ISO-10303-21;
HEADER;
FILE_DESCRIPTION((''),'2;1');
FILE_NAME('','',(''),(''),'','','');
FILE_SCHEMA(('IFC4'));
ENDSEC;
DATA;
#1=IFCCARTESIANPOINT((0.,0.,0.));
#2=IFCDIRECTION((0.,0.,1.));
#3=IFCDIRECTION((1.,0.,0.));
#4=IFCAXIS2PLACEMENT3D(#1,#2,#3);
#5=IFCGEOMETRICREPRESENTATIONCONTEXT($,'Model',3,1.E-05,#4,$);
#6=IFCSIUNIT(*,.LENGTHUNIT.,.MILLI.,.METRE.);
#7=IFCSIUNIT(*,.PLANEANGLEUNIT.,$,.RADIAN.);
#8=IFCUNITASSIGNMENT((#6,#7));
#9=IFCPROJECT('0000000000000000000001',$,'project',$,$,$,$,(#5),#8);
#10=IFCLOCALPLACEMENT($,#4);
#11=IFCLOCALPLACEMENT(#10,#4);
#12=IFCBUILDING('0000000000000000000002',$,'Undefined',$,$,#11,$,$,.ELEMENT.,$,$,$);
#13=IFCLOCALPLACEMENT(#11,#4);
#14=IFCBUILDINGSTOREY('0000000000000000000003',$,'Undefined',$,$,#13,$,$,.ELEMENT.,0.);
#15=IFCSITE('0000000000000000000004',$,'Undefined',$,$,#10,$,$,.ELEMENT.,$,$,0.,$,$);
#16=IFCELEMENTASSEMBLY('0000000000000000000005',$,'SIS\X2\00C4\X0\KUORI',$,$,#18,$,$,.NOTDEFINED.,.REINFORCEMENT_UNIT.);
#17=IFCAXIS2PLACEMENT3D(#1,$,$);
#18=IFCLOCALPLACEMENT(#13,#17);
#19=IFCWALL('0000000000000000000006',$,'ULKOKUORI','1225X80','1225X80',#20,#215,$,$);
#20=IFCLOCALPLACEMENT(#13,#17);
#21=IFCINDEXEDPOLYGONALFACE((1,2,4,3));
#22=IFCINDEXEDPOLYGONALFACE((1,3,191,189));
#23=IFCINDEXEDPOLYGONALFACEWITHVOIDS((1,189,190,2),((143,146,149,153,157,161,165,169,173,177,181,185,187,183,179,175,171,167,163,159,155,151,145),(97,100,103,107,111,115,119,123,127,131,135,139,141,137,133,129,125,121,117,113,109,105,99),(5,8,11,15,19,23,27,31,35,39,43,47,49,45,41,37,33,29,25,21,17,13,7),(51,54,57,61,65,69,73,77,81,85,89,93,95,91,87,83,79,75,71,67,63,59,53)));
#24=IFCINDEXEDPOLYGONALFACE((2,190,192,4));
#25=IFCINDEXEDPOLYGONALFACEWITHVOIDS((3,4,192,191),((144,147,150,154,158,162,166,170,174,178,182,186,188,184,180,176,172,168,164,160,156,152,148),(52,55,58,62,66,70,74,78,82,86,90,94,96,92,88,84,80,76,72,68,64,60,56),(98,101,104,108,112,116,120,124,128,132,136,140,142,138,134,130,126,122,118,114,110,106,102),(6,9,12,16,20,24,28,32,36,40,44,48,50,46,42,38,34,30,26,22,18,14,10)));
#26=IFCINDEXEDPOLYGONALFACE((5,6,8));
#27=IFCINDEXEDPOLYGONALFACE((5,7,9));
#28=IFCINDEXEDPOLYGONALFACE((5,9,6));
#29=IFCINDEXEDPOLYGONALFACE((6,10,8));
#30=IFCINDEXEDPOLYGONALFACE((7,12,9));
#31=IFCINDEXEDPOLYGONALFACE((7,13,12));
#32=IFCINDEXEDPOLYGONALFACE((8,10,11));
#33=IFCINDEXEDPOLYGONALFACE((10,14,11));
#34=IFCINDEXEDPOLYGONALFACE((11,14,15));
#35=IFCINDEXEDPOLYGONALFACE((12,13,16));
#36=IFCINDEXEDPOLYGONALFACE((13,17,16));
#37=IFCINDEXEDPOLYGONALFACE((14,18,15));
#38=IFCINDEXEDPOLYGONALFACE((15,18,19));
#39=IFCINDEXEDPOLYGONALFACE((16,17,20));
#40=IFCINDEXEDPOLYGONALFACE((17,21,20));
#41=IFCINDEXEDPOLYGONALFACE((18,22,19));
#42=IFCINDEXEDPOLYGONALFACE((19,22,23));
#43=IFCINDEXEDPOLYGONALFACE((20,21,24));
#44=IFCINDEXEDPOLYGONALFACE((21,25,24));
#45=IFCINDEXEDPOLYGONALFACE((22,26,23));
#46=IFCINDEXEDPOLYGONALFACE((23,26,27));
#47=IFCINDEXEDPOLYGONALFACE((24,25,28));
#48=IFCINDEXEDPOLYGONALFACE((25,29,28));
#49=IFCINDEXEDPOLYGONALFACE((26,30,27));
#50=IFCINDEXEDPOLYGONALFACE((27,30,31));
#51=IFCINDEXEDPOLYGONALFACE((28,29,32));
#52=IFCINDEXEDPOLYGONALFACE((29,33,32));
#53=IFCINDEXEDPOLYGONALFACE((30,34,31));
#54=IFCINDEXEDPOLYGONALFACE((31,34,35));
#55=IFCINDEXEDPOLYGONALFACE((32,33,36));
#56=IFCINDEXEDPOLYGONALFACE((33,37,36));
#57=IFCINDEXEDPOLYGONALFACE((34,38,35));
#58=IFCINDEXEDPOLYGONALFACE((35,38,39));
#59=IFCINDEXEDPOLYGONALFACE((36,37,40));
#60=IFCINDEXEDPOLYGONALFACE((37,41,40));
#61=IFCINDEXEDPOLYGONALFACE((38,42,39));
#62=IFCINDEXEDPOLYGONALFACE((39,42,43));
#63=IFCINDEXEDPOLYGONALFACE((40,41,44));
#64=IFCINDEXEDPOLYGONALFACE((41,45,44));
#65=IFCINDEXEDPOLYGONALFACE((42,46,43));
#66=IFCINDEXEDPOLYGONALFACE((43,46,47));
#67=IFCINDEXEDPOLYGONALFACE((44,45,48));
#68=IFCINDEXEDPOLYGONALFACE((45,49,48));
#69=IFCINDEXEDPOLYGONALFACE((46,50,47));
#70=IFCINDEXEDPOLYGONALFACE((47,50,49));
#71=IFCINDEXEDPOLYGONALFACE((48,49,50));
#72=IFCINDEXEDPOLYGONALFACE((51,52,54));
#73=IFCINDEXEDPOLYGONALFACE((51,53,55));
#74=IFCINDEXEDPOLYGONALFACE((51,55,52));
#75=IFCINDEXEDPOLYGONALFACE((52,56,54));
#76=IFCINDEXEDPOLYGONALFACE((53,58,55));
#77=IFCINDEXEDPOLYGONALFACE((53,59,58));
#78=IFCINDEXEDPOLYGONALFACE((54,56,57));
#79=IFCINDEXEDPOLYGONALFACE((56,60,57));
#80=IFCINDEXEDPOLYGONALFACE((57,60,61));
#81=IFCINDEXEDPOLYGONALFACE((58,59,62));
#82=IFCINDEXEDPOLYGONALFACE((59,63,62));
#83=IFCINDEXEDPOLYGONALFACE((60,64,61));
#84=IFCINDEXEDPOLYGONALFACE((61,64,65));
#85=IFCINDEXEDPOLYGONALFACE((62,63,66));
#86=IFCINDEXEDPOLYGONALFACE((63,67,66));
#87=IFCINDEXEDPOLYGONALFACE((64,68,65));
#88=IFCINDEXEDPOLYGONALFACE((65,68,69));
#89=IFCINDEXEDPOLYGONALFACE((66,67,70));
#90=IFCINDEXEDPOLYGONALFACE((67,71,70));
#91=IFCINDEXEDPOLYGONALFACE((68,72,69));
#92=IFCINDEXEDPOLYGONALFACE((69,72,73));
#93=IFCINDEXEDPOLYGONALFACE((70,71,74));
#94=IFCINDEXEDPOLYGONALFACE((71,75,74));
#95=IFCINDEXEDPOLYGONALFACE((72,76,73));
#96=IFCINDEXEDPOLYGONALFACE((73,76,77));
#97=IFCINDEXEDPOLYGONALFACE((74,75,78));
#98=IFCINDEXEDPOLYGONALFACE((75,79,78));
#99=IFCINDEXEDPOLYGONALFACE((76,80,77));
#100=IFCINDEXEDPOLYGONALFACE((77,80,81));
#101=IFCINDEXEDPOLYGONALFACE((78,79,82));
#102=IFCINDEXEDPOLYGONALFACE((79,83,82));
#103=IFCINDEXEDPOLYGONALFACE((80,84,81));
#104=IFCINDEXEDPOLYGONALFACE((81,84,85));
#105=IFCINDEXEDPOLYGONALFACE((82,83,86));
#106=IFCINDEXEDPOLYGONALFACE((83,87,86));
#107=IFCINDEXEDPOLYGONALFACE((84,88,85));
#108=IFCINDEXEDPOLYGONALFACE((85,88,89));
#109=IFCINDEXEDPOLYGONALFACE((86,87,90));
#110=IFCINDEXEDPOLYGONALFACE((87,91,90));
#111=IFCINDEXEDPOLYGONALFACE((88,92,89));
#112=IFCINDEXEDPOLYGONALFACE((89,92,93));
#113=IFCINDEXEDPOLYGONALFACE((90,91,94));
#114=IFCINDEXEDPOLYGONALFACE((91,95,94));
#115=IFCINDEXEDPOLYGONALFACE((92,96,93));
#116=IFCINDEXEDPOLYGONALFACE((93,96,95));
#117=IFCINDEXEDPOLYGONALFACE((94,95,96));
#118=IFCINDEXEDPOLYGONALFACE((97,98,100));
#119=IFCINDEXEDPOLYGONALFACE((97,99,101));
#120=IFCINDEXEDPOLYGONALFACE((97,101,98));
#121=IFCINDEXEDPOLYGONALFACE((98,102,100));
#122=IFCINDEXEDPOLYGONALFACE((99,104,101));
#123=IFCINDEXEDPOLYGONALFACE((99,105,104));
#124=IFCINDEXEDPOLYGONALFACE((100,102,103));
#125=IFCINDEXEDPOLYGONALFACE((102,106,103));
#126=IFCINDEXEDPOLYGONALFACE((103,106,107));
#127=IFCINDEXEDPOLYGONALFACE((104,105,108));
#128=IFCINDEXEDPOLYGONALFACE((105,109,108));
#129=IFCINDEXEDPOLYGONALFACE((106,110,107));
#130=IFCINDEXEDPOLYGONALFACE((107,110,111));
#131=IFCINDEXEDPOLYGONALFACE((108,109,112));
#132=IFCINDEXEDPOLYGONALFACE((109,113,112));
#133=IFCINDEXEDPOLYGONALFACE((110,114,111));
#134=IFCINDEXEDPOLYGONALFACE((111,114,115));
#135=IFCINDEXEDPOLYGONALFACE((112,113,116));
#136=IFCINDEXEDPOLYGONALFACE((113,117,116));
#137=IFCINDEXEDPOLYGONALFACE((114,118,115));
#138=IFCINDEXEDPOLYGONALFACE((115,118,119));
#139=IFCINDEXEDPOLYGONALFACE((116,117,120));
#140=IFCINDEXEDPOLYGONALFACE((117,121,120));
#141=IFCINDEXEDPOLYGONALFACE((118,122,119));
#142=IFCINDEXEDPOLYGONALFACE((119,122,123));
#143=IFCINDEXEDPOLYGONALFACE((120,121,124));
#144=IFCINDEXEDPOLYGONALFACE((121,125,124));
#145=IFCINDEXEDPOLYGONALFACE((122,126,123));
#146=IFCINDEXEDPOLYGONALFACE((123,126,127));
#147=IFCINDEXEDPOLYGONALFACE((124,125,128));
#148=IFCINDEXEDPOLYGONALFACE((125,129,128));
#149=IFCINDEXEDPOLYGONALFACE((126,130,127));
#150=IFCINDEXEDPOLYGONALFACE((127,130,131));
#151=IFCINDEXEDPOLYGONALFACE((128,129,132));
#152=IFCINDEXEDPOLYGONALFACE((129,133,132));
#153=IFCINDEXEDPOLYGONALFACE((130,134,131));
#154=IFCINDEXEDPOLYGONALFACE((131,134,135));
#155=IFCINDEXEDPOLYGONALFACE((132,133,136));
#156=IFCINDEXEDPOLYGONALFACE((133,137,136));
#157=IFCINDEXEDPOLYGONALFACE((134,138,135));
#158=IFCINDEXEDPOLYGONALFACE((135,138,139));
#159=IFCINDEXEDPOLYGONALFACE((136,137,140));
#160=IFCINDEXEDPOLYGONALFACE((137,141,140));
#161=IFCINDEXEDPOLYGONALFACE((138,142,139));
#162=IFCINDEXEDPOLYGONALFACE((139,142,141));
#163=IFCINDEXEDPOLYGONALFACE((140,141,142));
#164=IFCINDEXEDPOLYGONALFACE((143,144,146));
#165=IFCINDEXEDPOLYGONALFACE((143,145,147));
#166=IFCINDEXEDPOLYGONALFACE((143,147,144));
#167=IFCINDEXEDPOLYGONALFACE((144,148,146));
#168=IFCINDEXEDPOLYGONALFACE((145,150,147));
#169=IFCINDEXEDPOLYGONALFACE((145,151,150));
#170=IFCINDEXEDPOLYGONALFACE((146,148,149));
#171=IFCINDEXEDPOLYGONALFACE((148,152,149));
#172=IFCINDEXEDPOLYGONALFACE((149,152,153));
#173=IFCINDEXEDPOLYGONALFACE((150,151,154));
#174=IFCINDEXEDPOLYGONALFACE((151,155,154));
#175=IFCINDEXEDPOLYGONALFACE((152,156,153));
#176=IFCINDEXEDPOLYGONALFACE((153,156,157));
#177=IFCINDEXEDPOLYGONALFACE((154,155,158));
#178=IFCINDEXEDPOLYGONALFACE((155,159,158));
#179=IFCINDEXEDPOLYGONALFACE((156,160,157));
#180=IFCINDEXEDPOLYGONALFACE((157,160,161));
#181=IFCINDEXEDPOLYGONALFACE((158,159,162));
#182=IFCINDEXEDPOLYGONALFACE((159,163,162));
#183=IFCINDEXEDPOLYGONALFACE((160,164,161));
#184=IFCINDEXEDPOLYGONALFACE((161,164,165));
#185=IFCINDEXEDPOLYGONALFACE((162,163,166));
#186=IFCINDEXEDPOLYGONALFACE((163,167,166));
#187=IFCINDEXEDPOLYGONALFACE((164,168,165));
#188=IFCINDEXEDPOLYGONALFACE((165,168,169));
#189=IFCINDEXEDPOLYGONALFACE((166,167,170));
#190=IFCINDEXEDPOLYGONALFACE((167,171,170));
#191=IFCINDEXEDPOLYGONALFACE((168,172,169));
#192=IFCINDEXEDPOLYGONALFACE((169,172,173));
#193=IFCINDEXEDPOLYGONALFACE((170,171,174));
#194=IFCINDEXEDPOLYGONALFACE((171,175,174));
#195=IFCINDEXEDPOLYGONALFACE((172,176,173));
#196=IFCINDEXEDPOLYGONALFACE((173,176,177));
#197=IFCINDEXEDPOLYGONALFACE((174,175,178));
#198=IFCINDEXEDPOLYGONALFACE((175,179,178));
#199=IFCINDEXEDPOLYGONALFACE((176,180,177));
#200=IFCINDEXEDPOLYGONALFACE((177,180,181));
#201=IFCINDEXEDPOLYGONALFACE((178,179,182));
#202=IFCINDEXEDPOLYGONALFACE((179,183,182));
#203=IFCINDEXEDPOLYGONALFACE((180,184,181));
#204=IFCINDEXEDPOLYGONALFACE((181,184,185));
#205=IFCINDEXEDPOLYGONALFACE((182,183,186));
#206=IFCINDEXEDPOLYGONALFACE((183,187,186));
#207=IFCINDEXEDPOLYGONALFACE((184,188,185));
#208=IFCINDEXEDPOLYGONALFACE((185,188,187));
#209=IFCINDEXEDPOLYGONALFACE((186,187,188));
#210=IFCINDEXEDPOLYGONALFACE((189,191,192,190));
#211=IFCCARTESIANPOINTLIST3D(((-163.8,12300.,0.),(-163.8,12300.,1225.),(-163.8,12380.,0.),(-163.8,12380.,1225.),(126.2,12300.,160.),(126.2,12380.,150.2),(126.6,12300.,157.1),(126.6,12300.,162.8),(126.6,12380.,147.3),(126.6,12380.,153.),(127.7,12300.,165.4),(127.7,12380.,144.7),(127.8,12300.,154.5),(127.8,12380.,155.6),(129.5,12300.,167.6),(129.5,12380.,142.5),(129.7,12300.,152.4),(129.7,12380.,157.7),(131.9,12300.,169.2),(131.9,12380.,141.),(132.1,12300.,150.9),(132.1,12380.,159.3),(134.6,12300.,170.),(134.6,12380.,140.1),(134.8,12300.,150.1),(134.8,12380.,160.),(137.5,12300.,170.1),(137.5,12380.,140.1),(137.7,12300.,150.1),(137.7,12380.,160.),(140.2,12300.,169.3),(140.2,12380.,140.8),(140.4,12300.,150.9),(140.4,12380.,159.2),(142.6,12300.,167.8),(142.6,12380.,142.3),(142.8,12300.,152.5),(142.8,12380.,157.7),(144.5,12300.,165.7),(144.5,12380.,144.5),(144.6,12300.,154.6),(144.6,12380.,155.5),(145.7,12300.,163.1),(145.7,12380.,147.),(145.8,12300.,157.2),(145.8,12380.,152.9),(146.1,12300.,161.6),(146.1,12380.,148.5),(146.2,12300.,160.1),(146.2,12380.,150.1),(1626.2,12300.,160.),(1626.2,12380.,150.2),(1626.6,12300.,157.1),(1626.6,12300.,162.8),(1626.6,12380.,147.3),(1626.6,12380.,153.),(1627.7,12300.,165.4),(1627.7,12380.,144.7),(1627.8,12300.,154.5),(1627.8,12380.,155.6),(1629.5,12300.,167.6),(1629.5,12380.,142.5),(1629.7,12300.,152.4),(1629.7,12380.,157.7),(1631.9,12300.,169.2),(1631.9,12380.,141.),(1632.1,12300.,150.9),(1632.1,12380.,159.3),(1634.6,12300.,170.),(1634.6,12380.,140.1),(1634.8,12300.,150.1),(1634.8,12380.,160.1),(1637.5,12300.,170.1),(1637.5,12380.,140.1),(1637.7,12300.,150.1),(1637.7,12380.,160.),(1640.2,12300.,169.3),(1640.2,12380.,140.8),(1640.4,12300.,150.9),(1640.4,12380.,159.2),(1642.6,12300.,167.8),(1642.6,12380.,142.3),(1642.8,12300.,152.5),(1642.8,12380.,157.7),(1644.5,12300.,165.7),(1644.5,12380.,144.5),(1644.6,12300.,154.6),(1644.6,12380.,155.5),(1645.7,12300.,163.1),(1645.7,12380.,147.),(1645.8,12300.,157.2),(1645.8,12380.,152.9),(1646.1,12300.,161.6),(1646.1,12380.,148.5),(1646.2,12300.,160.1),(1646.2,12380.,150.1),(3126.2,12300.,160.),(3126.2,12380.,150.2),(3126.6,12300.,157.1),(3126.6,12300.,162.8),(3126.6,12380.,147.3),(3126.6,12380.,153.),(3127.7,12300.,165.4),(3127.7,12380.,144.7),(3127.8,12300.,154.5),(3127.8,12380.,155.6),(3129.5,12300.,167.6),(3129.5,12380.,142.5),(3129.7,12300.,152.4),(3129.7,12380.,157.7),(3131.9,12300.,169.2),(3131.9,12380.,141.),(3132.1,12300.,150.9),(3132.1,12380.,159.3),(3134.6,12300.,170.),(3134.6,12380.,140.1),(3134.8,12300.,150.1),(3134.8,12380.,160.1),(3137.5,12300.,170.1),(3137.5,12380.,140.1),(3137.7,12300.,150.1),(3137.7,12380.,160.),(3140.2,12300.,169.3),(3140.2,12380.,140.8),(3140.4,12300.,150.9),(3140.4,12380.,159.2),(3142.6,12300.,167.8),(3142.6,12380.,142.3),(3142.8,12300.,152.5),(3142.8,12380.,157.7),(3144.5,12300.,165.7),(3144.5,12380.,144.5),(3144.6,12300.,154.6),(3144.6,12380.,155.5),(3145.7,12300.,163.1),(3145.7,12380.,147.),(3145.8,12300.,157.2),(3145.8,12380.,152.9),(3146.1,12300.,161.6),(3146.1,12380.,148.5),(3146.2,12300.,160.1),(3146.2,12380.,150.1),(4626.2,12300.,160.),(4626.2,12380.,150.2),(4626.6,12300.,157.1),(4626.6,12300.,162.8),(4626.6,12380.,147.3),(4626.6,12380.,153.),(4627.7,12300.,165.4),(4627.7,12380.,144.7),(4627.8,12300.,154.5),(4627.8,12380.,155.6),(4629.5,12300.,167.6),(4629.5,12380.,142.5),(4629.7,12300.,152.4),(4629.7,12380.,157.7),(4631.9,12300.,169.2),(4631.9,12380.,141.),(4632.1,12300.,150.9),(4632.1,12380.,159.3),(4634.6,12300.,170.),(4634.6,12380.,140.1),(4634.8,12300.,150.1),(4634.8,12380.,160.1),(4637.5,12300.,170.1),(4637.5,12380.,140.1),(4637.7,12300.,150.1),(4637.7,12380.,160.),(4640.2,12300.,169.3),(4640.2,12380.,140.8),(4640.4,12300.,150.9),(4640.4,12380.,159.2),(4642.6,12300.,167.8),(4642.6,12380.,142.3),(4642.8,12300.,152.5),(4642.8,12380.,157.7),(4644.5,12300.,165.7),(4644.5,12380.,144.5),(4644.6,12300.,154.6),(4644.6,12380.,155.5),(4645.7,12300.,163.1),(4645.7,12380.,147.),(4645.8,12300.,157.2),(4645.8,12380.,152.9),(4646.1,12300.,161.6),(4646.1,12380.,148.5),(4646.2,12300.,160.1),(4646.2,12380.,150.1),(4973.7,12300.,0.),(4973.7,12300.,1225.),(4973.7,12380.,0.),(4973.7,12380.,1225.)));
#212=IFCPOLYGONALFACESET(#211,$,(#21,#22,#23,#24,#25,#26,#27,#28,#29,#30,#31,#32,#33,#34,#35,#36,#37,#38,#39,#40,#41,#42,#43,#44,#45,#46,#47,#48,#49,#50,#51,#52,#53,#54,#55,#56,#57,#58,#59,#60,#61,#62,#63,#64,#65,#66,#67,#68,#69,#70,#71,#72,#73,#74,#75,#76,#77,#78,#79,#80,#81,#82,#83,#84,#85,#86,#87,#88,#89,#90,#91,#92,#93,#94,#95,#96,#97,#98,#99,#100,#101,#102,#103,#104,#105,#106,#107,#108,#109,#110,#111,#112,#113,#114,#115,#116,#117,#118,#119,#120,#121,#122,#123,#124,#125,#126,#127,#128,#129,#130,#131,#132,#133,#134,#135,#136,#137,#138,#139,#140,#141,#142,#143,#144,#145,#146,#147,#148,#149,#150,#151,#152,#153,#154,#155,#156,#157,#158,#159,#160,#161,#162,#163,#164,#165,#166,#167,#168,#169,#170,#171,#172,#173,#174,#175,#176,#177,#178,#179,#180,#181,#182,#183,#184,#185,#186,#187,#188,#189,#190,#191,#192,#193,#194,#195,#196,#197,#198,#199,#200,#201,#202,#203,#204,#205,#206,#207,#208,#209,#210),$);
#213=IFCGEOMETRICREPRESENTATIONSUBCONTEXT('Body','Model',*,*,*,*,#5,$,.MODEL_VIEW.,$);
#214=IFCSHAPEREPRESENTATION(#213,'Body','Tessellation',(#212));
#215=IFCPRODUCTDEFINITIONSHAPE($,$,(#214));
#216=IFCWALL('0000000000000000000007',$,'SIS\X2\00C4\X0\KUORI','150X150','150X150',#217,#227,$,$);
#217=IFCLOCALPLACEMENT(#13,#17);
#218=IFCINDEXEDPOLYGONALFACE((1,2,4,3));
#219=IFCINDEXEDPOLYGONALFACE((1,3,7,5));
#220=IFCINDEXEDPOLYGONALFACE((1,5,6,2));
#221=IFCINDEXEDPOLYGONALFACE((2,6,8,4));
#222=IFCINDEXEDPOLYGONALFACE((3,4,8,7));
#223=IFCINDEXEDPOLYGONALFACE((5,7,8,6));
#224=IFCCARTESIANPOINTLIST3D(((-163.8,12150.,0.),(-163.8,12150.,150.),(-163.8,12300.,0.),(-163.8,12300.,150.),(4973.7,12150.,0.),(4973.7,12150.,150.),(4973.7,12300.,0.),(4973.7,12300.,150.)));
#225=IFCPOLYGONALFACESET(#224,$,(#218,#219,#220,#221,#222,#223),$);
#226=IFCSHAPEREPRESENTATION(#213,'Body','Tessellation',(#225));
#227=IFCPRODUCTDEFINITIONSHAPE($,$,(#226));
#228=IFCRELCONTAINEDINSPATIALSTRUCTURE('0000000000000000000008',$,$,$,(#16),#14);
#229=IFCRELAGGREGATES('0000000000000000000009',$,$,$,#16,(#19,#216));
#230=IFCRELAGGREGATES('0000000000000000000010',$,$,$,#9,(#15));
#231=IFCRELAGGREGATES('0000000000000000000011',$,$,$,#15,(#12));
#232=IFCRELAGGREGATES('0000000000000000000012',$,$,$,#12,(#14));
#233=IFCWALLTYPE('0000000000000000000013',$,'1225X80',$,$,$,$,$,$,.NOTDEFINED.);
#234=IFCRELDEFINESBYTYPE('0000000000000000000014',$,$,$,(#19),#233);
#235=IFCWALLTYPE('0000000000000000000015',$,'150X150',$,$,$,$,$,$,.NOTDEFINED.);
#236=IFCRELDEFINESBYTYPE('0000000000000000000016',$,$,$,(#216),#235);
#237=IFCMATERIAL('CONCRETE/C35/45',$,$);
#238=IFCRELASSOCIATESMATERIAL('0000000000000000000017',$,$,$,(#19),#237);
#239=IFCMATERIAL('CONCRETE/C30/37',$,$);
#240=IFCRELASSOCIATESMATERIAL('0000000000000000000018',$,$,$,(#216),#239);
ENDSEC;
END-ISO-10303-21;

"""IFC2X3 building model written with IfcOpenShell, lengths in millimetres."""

from ifc_helpers import new_model, si_unit, frame, frame_2d, origin_with_axes, origin_2d_with_axis, place, context, subcontext, project, spatial, rectangle, circle, extrude, boolean, material, type_object, element, aggregate, save


model = new_model("IFC2X3")

# Units and contexts
model_context = context("Model", 3, precision=1e-05, world=origin_with_axes())
body_context = subcontext(model_context, "Body", "Model", "MODEL_VIEW")
ifc_project = project(units=[si_unit("LENGTHUNIT", "METRE", prefix="MILLI"), si_unit("PLANEANGLEUNIT", "RADIAN")], contexts=[model_context])

# Site, building, storey
site_placement = place(None, origin_with_axes())
site = spatial("IfcSite", under=ifc_project, at=site_placement, Name="Undefined", CompositionType="ELEMENT", RefElevation=0.0)
building_placement = place(site_placement, origin_with_axes())
building = spatial("IfcBuilding", under=site, at=building_placement, Name="Undefined", CompositionType="ELEMENT")
storey_placement = place(building_placement, origin_with_axes())
storey = spatial("IfcBuildingStorey", under=building, at=storey_placement, Name="Undefined", CompositionType="ELEMENT", Elevation=0.0)

# Element assembly
assembly_1_placement = place(storey_placement, origin_with_axes())
assembly_1 = element("IfcElementAssembly", 1, at=assembly_1_placement, inside=storey, Name="SISÄKUORI", AssemblyPlace="NOTDEFINED", PredefinedType="REINFORCEMENT_UNIT")
ifc_material_1 = material(Name="CONCRETE/C30/37")

# Walls
ifc_material_2 = material(Name="CONCRETE/C35/45")
wall_type_1 = type_object("IfcWallType", Name="1225X80", PredefinedType="NOTDEFINED")
wall_1_placement = place(assembly_1_placement, frame((-163.8, 12340.0, 0.0), z_axis=(0.0, 0.0, 1.0), x_axis=(1.0, -0.000003, 0.0)))
wall_1 = element("IfcWall", 2, at=wall_1_placement, type_object=wall_type_1, material=ifc_material_2, Name="ULKOKUORI", Description="1225X80", ObjectType="1225X80", context=body_context, shape_type="CSG", body=[
    boolean("DIFFERENCE", boolean("DIFFERENCE", boolean("DIFFERENCE", boolean("DIFFERENCE", extrude(rectangle(XDim=5137.5, YDim=80.0, at=frame_2d((0.0, 2568.7), x_axis=(0.0, -1.0))), frame((0.0, 0.0, 0.0), z_axis=(0.0, 0.0, 1.0), x_axis=(0.0, -1.0, 0.0)), (0.0, 0.0, 1.0), 1225.0), extrude(circle(Radius=10.0, at=origin_2d_with_axis()), frame((300.0, 51.2, 148.7), z_axis=(0.000003, -0.992278, 0.124035), x_axis=(1.0, 0.000003, 0.0)), (0.0, 0.0, 1.0), 100.6)), extrude(circle(Radius=10.0, at=origin_2d_with_axis()), frame((1800.0, 51.2, 148.7), z_axis=(0.000003, -0.992278, 0.124035), x_axis=(1.0, 0.000003, 0.0)), (0.0, 0.0, 1.0), 100.6)), extrude(circle(Radius=10.0, at=origin_2d_with_axis()), frame((3300.0, 51.2, 148.7), z_axis=(0.000003, -0.992278, 0.124035), x_axis=(1.0, 0.000003, 0.0)), (0.0, 0.0, 1.0), 100.6)), extrude(circle(Radius=10.0, at=origin_2d_with_axis()), frame((4800.0, 51.2, 148.7), z_axis=(0.000003, -0.992278, 0.124035), x_axis=(1.0, 0.000003, 0.0)), (0.0, 0.0, 1.0), 100.6)),
])
wall_type_2 = type_object("IfcWallType", Name="150X150", PredefinedType="NOTDEFINED")
wall_2_placement = place(assembly_1_placement, frame((-163.8, 12225.0, 0.0), z_axis=(0.0, 0.0, 1.0), x_axis=(1.0, -0.000003, 0.0)))
wall_2 = element("IfcWall", 3, at=wall_2_placement, type_object=wall_type_2, material=ifc_material_1, Name="SISÄKUORI", Description="150X150", ObjectType="150X150", context=body_context, shape_type="SweptSolid", body=[
    extrude(rectangle(XDim=5137.5, YDim=150.0, at=frame_2d((0.0, 2568.7), x_axis=(0.0, -1.0))), frame((0.0, 0.0, 0.0), z_axis=(0.0, 0.0, 1.0), x_axis=(0.0, -1.0, 0.0)), (0.0, 0.0, 1.0), 150.0),
])

aggregate(assembly_1, [wall_1, wall_2])

save(model, "model.ifc")
